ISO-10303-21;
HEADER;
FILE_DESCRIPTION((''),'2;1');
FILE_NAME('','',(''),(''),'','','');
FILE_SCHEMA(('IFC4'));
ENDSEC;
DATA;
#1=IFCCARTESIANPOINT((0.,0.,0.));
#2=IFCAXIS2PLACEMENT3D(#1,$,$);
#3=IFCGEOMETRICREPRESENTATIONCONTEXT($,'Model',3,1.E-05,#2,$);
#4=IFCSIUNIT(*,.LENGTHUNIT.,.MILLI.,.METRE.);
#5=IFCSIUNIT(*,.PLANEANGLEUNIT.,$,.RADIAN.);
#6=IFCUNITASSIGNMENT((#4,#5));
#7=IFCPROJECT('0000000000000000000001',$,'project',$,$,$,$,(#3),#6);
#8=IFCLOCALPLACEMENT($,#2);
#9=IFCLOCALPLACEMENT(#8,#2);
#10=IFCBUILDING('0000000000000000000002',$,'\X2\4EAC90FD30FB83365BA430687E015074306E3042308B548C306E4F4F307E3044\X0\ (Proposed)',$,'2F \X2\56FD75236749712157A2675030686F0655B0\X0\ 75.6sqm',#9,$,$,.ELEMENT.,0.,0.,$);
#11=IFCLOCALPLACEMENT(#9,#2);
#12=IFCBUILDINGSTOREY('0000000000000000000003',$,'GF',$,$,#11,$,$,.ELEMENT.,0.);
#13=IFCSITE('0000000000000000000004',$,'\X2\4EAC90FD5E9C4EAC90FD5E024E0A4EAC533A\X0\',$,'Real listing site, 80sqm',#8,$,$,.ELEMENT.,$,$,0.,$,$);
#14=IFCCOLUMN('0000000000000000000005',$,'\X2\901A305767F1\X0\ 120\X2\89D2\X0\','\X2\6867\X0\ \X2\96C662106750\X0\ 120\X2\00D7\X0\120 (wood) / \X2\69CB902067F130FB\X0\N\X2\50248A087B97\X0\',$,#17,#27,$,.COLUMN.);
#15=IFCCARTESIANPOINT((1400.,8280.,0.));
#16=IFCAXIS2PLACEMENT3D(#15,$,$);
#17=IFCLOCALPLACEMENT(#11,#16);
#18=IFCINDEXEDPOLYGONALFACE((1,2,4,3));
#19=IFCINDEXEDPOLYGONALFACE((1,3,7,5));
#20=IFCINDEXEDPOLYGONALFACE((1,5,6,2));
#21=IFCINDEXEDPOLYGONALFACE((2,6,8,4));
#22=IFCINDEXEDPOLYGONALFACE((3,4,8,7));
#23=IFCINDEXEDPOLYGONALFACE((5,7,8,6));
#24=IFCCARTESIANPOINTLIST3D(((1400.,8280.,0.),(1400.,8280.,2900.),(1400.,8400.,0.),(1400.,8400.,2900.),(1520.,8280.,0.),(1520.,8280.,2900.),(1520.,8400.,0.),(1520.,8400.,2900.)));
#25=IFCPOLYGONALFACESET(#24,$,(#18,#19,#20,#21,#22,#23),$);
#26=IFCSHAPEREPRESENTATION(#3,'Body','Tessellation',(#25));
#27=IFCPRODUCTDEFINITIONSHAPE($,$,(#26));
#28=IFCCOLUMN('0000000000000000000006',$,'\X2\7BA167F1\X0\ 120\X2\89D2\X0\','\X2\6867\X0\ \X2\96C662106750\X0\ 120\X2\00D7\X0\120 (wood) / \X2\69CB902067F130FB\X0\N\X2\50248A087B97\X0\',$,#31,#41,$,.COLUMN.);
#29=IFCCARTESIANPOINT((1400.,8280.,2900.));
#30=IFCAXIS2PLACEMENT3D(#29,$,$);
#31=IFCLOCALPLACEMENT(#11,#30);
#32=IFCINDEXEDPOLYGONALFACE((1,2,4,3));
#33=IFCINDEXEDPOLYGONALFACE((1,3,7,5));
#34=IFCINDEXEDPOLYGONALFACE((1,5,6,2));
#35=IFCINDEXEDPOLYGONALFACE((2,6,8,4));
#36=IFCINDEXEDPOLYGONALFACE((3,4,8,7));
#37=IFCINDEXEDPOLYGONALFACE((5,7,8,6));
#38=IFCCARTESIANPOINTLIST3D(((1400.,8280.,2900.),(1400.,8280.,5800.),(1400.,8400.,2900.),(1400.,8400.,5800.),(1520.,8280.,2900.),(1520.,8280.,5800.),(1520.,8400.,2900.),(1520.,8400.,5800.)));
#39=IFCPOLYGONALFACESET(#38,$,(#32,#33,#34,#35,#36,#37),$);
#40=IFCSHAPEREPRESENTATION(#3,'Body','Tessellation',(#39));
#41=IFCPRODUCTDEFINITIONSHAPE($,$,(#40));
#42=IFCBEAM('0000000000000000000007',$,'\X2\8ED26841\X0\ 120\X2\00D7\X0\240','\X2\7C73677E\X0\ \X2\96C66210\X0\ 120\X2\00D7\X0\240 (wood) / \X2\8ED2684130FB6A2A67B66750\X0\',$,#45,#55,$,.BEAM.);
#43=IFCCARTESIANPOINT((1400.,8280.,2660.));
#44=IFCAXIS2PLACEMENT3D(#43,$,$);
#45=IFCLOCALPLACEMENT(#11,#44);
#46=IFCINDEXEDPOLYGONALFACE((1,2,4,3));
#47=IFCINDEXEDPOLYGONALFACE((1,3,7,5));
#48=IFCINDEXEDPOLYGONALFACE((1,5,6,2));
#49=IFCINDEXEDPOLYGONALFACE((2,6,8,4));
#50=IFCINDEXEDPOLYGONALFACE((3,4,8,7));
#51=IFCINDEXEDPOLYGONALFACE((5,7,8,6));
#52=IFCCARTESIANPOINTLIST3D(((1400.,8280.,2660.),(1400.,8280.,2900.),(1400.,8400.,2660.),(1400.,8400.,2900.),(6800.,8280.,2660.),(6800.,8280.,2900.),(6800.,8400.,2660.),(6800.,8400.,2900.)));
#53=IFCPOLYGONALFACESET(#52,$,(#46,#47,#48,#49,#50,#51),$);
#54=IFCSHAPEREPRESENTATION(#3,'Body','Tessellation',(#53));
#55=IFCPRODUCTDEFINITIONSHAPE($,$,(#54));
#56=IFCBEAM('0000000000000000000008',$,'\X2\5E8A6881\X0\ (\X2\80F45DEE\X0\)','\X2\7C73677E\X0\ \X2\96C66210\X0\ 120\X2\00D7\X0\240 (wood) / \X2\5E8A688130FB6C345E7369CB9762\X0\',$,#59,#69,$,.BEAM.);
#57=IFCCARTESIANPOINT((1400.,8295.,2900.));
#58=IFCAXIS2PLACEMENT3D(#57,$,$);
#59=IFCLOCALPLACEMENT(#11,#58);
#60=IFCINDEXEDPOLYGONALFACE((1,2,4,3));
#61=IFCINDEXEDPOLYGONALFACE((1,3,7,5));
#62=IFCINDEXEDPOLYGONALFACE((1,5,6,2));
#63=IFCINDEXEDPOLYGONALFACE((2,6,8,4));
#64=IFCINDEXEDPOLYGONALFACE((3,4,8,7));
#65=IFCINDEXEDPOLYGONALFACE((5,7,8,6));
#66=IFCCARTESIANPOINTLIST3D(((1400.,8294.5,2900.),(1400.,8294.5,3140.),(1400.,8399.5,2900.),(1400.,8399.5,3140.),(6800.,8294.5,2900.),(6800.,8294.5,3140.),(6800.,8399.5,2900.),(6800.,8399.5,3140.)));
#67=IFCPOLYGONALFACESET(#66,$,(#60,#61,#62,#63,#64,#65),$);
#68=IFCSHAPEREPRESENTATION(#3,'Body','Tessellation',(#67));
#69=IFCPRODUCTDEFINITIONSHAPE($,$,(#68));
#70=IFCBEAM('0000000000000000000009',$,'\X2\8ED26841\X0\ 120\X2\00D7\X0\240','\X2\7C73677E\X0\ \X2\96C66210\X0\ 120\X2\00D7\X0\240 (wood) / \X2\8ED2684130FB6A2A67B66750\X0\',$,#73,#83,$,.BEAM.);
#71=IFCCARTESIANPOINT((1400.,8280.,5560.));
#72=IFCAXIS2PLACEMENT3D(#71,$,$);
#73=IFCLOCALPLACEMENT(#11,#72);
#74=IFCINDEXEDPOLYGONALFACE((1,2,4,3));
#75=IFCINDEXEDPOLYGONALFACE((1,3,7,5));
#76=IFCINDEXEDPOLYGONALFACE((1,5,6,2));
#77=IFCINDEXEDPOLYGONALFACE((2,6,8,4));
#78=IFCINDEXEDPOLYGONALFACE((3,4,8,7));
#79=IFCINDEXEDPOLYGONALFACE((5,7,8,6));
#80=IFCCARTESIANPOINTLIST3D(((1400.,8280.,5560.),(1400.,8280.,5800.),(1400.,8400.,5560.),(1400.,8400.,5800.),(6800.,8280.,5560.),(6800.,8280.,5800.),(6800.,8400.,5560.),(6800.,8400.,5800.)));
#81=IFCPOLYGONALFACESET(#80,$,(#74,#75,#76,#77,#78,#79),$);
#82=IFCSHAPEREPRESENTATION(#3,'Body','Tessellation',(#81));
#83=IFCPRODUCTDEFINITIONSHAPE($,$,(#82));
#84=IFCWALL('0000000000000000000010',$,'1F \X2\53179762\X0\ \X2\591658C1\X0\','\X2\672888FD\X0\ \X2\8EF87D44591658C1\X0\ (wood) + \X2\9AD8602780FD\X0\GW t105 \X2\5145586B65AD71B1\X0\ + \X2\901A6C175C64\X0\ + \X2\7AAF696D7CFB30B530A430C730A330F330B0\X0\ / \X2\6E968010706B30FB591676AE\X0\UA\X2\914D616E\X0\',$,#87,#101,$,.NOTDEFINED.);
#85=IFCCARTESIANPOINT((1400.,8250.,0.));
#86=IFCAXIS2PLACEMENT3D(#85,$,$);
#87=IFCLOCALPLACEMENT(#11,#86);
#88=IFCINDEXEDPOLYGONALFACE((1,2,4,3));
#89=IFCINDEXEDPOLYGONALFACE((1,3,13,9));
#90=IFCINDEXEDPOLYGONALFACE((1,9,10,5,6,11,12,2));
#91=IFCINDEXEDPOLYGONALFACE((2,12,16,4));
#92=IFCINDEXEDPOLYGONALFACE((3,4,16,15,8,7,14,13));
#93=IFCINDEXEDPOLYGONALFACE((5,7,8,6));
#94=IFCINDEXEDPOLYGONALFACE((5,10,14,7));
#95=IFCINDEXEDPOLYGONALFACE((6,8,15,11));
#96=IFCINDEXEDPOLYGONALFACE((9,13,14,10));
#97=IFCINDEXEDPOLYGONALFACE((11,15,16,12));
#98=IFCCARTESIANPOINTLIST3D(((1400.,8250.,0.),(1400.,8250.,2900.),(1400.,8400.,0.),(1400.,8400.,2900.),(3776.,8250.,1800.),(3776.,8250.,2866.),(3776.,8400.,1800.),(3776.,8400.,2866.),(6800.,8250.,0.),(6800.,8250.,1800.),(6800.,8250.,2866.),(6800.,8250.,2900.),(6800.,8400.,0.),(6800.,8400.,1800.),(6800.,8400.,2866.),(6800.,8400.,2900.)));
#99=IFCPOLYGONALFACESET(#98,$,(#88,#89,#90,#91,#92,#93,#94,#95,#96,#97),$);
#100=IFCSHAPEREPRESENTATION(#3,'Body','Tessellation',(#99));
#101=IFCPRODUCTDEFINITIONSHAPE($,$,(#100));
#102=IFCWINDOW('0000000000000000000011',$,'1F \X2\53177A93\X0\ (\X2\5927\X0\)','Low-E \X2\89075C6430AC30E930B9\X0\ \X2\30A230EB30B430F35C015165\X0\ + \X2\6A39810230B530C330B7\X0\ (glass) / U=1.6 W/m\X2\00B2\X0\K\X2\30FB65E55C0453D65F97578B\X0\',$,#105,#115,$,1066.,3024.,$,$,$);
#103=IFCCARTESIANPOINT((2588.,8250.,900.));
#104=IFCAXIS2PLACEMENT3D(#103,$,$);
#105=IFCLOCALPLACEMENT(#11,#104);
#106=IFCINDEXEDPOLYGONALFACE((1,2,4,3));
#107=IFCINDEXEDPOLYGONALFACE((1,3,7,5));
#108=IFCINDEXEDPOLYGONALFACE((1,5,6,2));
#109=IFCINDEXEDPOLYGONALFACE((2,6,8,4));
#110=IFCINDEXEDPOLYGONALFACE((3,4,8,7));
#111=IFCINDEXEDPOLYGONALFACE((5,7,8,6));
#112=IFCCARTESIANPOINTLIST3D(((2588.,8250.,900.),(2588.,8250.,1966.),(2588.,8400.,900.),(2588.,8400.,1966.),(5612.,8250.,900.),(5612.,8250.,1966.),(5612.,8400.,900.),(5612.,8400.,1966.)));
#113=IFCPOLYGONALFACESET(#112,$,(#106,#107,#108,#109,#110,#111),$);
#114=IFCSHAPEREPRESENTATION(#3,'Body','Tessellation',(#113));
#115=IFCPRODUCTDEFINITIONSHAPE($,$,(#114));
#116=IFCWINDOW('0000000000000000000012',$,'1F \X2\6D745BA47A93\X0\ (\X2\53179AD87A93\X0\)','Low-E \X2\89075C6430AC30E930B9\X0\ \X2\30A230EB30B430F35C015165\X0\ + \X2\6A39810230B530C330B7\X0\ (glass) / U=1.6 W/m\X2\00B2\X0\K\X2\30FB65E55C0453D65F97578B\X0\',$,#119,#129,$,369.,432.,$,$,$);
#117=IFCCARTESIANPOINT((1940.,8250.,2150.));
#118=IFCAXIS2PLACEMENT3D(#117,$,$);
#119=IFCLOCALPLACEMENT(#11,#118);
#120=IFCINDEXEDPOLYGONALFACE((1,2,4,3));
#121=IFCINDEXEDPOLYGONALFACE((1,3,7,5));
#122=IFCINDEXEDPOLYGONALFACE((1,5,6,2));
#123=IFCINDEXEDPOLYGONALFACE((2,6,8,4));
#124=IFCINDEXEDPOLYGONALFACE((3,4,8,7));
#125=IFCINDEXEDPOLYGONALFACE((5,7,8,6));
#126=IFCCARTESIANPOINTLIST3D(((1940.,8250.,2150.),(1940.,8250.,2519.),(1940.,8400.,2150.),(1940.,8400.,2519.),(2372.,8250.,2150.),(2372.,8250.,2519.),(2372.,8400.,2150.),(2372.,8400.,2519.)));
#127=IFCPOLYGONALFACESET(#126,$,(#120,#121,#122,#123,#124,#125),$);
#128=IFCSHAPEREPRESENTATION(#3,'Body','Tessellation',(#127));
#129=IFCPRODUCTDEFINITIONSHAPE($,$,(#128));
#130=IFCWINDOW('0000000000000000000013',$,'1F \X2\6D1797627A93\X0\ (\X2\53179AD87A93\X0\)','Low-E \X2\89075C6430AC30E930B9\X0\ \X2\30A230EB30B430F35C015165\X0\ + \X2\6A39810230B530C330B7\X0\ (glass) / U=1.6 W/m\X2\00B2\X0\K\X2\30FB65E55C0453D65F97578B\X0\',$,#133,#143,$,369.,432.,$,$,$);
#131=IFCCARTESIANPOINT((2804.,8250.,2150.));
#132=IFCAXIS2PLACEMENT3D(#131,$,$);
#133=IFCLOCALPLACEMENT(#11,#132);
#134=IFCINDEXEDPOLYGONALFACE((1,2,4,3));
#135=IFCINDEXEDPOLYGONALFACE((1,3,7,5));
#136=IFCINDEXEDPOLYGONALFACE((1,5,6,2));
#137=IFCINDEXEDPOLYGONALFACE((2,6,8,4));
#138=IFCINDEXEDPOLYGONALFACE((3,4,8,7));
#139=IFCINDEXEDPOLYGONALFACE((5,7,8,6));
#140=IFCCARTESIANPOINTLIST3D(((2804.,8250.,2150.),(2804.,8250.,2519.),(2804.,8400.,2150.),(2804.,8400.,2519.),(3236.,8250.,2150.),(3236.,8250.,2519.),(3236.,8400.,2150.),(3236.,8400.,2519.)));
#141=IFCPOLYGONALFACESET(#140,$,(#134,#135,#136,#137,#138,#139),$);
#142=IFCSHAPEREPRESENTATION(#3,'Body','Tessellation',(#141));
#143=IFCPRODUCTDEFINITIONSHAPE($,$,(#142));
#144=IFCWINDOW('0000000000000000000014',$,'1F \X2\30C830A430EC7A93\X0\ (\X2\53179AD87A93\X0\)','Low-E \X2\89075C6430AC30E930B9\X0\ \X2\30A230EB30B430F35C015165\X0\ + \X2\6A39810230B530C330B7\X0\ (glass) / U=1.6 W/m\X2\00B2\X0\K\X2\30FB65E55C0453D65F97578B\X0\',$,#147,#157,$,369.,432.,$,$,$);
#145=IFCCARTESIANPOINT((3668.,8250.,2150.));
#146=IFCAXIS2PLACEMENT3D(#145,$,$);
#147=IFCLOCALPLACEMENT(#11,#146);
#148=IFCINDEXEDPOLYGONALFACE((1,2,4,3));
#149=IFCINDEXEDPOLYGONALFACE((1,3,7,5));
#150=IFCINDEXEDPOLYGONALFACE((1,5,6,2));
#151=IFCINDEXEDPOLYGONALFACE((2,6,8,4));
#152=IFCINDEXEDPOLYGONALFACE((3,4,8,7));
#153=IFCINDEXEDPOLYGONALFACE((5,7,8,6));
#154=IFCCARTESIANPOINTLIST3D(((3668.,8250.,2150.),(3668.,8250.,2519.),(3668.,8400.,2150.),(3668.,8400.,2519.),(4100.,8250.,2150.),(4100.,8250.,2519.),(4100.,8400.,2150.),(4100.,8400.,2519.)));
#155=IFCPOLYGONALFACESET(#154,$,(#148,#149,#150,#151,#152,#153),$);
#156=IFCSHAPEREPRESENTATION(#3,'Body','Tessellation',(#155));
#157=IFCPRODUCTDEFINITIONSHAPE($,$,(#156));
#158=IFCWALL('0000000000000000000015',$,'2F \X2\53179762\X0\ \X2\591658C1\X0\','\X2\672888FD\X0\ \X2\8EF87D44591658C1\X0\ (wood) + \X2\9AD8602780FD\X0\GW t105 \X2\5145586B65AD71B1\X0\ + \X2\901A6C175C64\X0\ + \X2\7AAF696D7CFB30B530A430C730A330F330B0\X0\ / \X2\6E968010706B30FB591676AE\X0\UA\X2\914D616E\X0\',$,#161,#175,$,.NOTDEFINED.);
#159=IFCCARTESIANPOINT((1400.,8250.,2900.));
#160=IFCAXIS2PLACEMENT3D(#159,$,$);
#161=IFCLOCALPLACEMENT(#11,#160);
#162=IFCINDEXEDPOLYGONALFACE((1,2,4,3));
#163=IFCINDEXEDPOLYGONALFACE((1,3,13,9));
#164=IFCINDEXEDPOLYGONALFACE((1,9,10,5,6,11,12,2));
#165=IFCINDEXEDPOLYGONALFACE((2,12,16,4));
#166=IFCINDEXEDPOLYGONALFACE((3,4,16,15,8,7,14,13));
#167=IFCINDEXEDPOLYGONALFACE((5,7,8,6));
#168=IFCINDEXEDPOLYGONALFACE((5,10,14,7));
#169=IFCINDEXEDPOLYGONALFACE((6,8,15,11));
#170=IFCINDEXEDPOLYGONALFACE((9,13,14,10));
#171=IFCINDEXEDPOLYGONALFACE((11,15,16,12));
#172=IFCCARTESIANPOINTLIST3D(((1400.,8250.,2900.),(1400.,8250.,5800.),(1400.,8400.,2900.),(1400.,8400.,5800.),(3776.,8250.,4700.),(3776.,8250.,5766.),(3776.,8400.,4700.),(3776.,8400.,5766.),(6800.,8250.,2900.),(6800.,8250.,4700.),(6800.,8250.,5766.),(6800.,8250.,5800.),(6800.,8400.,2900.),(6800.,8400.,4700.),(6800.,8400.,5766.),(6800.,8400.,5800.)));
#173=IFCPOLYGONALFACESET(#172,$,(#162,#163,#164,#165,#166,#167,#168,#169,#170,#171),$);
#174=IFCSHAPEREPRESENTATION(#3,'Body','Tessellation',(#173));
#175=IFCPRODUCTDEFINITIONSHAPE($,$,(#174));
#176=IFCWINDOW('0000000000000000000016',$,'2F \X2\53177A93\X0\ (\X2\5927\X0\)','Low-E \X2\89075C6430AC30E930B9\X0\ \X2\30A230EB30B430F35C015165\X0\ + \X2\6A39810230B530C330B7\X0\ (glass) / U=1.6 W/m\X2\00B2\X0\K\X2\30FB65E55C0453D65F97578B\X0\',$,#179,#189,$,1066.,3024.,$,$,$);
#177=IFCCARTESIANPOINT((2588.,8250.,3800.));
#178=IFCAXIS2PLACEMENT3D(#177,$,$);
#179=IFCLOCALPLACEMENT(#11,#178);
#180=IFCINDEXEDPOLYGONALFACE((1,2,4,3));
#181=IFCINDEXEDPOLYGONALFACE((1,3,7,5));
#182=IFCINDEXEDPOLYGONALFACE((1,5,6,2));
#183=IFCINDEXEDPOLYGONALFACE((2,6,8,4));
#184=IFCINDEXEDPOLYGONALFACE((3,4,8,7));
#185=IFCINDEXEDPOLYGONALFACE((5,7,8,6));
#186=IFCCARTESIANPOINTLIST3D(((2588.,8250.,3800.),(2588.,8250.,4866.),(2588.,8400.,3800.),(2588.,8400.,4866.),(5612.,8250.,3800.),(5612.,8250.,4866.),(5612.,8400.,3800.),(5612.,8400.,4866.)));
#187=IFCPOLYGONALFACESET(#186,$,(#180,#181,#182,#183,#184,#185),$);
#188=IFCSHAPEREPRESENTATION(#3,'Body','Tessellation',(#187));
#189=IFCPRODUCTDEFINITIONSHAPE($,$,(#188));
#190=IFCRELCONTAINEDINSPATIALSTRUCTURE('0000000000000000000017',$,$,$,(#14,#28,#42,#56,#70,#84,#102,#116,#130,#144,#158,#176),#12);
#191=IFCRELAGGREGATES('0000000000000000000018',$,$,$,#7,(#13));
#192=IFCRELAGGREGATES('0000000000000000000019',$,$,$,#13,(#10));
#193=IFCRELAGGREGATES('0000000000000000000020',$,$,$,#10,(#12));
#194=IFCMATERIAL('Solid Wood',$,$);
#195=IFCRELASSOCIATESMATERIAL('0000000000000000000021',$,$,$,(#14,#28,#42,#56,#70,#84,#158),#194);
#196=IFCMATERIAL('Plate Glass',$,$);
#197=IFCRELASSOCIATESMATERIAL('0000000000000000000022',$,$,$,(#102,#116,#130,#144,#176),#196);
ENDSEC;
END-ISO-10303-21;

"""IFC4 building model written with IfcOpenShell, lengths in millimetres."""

from ifc_helpers import new_model, si_unit, frame, frame_2d, origin, place, context, project, spatial, rectangle, extrude, material, element, fill, save


model = new_model("IFC4")

# Units and contexts
model_context = context("Model", 3, precision=1e-05, world=origin())
ifc_project = project(units=[si_unit("LENGTHUNIT", "METRE", prefix="MILLI"), si_unit("PLANEANGLEUNIT", "RADIAN")], contexts=[model_context])

# Site, building, storey
site_placement = place(None, origin())
site = spatial("IfcSite", under=ifc_project, at=site_placement, Name="京都府京都市上京区", ObjectType="Real listing site, 80sqm", CompositionType="ELEMENT", RefElevation=0.0)
building_placement = place(site_placement, origin())
building = spatial("IfcBuilding", under=site, at=building_placement, Name="京都・茶室と縁側のある和の住まい (Proposed)", ObjectType="2F 国産杉無垢材と漆喰 75.6sqm", CompositionType="ELEMENT", ElevationOfRefHeight=0.0, ElevationOfTerrain=0.0)
storey_placement = place(building_placement, origin())
storey = spatial("IfcBuildingStorey", under=building, at=storey_placement, Name="GF", CompositionType="ELEMENT", Elevation=0.0)

# Columns
ifc_material_1 = material(Name="Solid Wood")
column_1_placement = place(storey_placement, frame((1400.0, 8280.0, 0.0)))
element("IfcColumn", 1, at=column_1_placement, inside=storey, material=ifc_material_1, Name="通し柱 120角", Description="桧 集成材 120×120 (wood) / 構造柱・N値計算", PredefinedType="COLUMN", context=model_context, shape_type="SweptSolid", body=[
    extrude(rectangle(XDim=120.0, YDim=120.0, at=frame_2d((60.0, 60.0))), frame((1400.0, 8280.0, 0.0)), (0.0, 0.0, 1.0), 2900.0),
])
column_2_placement = place(storey_placement, frame((1400.0, 8280.0, 2900.0)))
element("IfcColumn", 2, at=column_2_placement, inside=storey, material=ifc_material_1, Name="管柱 120角", Description="桧 集成材 120×120 (wood) / 構造柱・N値計算", PredefinedType="COLUMN", context=model_context, shape_type="SweptSolid", body=[
    extrude(rectangle(XDim=120.0, YDim=120.0, at=frame_2d((60.0, 60.0))), frame((1400.0, 8280.0, 2900.0)), (0.0, 0.0, 1.0), 2900.0),
])

# Beams
beam_1_placement = place(storey_placement, frame((1400.0, 8280.0, 2660.0)))
element("IfcBeam", 3, at=beam_1_placement, inside=storey, material=ifc_material_1, Name="軒桁 120×240", Description="米松 集成 120×240 (wood) / 軒桁・横架材", PredefinedType="BEAM", context=model_context, shape_type="SweptSolid", body=[
    extrude(rectangle(XDim=5400.0, YDim=120.0, at=frame_2d((2700.0, 60.0))), frame((1400.0, 8280.0, 2660.0)), (0.0, 0.0, 1.0), 240.0),
])
beam_2_placement = place(storey_placement, frame((1400.0, 8295.0, 2900.0)))
element("IfcBeam", 4, at=beam_2_placement, inside=storey, material=ifc_material_1, Name="床梁 (胴差)", Description="米松 集成 120×240 (wood) / 床梁・水平構面", PredefinedType="BEAM", context=model_context, shape_type="SweptSolid", body=[
    extrude(rectangle(XDim=5400.0, YDim=105.0, at=frame_2d((2700.0, 52.0))), frame((1400.0, 8295.0, 2900.0)), (0.0, 0.0, 1.0), 240.0),
])
beam_3_placement = place(storey_placement, frame((1400.0, 8280.0, 5560.0)))
element("IfcBeam", 5, at=beam_3_placement, inside=storey, material=ifc_material_1, Name="軒桁 120×240", Description="米松 集成 120×240 (wood) / 軒桁・横架材", PredefinedType="BEAM", context=model_context, shape_type="SweptSolid", body=[
    extrude(rectangle(XDim=5400.0, YDim=120.0, at=frame_2d((2700.0, 60.0))), frame((1400.0, 8280.0, 5560.0)), (0.0, 0.0, 1.0), 240.0),
])

# Wall, openings, windows
wall_1_placement = place(storey_placement, frame((1400.0, 8250.0, 0.0)))
wall_1 = element("IfcWall", 6, at=wall_1_placement, inside=storey, material=ifc_material_1, Name="1F 北面 外壁", Description="木製 軸組外壁 (wood) + 高性能GW t105 充填断熱 + 通気層 + 窯業系サイディング / 準耐火・外皮UA配慮", PredefinedType="NOTDEFINED", context=model_context, shape_type="SweptSolid", body=[
    extrude(rectangle(XDim=5400.0, YDim=150.0, at=frame_2d((2700.0, 75.0))), frame((1400.0, 8250.0, 0.0)), (0.0, 0.0, 1.0), 2900.0),
])
opening_1_placement = place(storey_placement, frame((2588.0, 8250.0, 900.0)))
opening_1 = element("IfcOpeningElement", 7, at=opening_1_placement, cuts=wall_1, PredefinedType="NOTDEFINED", context=model_context, shape_type="SweptSolid", body=[
    extrude(rectangle(XDim=3024.0, YDim=150.0, at=frame_2d((1512.0, 75.0))), frame((2588.0, 8250.0, 900.0)), (0.0, 0.0, 1.0), 1066.0),
])
opening_2_placement = place(storey_placement, frame((1940.0, 8250.0, 2150.0)))
opening_2 = element("IfcOpeningElement", 8, at=opening_2_placement, cuts=wall_1, PredefinedType="NOTDEFINED", context=model_context, shape_type="SweptSolid", body=[
    extrude(rectangle(XDim=432.0, YDim=150.0, at=frame_2d((216.0, 75.0))), frame((1940.0, 8250.0, 2150.0)), (0.0, 0.0, 1.0), 369.0),
])
opening_3_placement = place(storey_placement, frame((2804.0, 8250.0, 2150.0)))
opening_3 = element("IfcOpeningElement", 9, at=opening_3_placement, cuts=wall_1, PredefinedType="NOTDEFINED", context=model_context, shape_type="SweptSolid", body=[
    extrude(rectangle(XDim=432.0, YDim=150.0, at=frame_2d((216.0, 75.0))), frame((2804.0, 8250.0, 2150.0)), (0.0, 0.0, 1.0), 369.0),
])
opening_4_placement = place(storey_placement, frame((3668.0, 8250.0, 2150.0)))
opening_4 = element("IfcOpeningElement", 10, at=opening_4_placement, cuts=wall_1, PredefinedType="NOTDEFINED", context=model_context, shape_type="SweptSolid", body=[
    extrude(rectangle(XDim=432.0, YDim=150.0, at=frame_2d((216.0, 75.0))), frame((3668.0, 8250.0, 2150.0)), (0.0, 0.0, 1.0), 369.0),
])
ifc_material_2 = material(Name="Plate Glass")
window_1_placement = place(storey_placement, frame((2588.0, 8250.0, 900.0)))
window_1 = element("IfcWindow", 11, at=window_1_placement, inside=storey, material=ifc_material_2, Name="1F 北窓 (大)", Description="Low-E 複層ガラス アルゴン封入 + 樹脂サッシ (glass) / U=1.6 W/m²K・日射取得型", OverallHeight=1066.0, OverallWidth=3024.0, context=model_context, shape_type="SweptSolid", body=[
    extrude(rectangle(XDim=3024.0, YDim=150.0, at=frame_2d((1512.0, 75.0))), frame((2588.0, 8250.0, 900.0)), (0.0, 0.0, 1.0), 1066.0),
])
fill(opening_1, window_1)
window_2_placement = place(storey_placement, frame((1940.0, 8250.0, 2150.0)))
window_2 = element("IfcWindow", 12, at=window_2_placement, inside=storey, material=ifc_material_2, Name="1F 浴室窓 (北高窓)", Description="Low-E 複層ガラス アルゴン封入 + 樹脂サッシ (glass) / U=1.6 W/m²K・日射取得型", OverallHeight=369.0, OverallWidth=432.0, context=model_context, shape_type="SweptSolid", body=[
    extrude(rectangle(XDim=432.0, YDim=150.0, at=frame_2d((216.0, 75.0))), frame((1940.0, 8250.0, 2150.0)), (0.0, 0.0, 1.0), 369.0),
])
fill(opening_2, window_2)
window_3_placement = place(storey_placement, frame((2804.0, 8250.0, 2150.0)))
window_3 = element("IfcWindow", 13, at=window_3_placement, inside=storey, material=ifc_material_2, Name="1F 洗面窓 (北高窓)", Description="Low-E 複層ガラス アルゴン封入 + 樹脂サッシ (glass) / U=1.6 W/m²K・日射取得型", OverallHeight=369.0, OverallWidth=432.0, context=model_context, shape_type="SweptSolid", body=[
    extrude(rectangle(XDim=432.0, YDim=150.0, at=frame_2d((216.0, 75.0))), frame((2804.0, 8250.0, 2150.0)), (0.0, 0.0, 1.0), 369.0),
])
fill(opening_3, window_3)
window_4_placement = place(storey_placement, frame((3668.0, 8250.0, 2150.0)))
window_4 = element("IfcWindow", 14, at=window_4_placement, inside=storey, material=ifc_material_2, Name="1F トイレ窓 (北高窓)", Description="Low-E 複層ガラス アルゴン封入 + 樹脂サッシ (glass) / U=1.6 W/m²K・日射取得型", OverallHeight=369.0, OverallWidth=432.0, context=model_context, shape_type="SweptSolid", body=[
    extrude(rectangle(XDim=432.0, YDim=150.0, at=frame_2d((216.0, 75.0))), frame((3668.0, 8250.0, 2150.0)), (0.0, 0.0, 1.0), 369.0),
])
fill(opening_4, window_4)

# Wall, opening, window
wall_2_placement = place(storey_placement, frame((1400.0, 8250.0, 2900.0)))
wall_2 = element("IfcWall", 15, at=wall_2_placement, inside=storey, material=ifc_material_1, Name="2F 北面 外壁", Description="木製 軸組外壁 (wood) + 高性能GW t105 充填断熱 + 通気層 + 窯業系サイディング / 準耐火・外皮UA配慮", PredefinedType="NOTDEFINED", context=model_context, shape_type="SweptSolid", body=[
    extrude(rectangle(XDim=5400.0, YDim=150.0, at=frame_2d((2700.0, 75.0))), frame((1400.0, 8250.0, 2900.0)), (0.0, 0.0, 1.0), 2900.0),
])
opening_5_placement = place(storey_placement, frame((2588.0, 8250.0, 3800.0)))
opening_5 = element("IfcOpeningElement", 16, at=opening_5_placement, cuts=wall_2, PredefinedType="NOTDEFINED", context=model_context, shape_type="SweptSolid", body=[
    extrude(rectangle(XDim=3024.0, YDim=150.0, at=frame_2d((1512.0, 75.0))), frame((2588.0, 8250.0, 3800.0)), (0.0, 0.0, 1.0), 1066.0),
])
window_5_placement = place(storey_placement, frame((2588.0, 8250.0, 3800.0)))
window_5 = element("IfcWindow", 17, at=window_5_placement, inside=storey, material=ifc_material_2, Name="2F 北窓 (大)", Description="Low-E 複層ガラス アルゴン封入 + 樹脂サッシ (glass) / U=1.6 W/m²K・日射取得型", OverallHeight=1066.0, OverallWidth=3024.0, context=model_context, shape_type="SweptSolid", body=[
    extrude(rectangle(XDim=3024.0, YDim=150.0, at=frame_2d((1512.0, 75.0))), frame((2588.0, 8250.0, 3800.0)), (0.0, 0.0, 1.0), 1066.0),
])
fill(opening_5, window_5)

save(model, "model.ifc")
